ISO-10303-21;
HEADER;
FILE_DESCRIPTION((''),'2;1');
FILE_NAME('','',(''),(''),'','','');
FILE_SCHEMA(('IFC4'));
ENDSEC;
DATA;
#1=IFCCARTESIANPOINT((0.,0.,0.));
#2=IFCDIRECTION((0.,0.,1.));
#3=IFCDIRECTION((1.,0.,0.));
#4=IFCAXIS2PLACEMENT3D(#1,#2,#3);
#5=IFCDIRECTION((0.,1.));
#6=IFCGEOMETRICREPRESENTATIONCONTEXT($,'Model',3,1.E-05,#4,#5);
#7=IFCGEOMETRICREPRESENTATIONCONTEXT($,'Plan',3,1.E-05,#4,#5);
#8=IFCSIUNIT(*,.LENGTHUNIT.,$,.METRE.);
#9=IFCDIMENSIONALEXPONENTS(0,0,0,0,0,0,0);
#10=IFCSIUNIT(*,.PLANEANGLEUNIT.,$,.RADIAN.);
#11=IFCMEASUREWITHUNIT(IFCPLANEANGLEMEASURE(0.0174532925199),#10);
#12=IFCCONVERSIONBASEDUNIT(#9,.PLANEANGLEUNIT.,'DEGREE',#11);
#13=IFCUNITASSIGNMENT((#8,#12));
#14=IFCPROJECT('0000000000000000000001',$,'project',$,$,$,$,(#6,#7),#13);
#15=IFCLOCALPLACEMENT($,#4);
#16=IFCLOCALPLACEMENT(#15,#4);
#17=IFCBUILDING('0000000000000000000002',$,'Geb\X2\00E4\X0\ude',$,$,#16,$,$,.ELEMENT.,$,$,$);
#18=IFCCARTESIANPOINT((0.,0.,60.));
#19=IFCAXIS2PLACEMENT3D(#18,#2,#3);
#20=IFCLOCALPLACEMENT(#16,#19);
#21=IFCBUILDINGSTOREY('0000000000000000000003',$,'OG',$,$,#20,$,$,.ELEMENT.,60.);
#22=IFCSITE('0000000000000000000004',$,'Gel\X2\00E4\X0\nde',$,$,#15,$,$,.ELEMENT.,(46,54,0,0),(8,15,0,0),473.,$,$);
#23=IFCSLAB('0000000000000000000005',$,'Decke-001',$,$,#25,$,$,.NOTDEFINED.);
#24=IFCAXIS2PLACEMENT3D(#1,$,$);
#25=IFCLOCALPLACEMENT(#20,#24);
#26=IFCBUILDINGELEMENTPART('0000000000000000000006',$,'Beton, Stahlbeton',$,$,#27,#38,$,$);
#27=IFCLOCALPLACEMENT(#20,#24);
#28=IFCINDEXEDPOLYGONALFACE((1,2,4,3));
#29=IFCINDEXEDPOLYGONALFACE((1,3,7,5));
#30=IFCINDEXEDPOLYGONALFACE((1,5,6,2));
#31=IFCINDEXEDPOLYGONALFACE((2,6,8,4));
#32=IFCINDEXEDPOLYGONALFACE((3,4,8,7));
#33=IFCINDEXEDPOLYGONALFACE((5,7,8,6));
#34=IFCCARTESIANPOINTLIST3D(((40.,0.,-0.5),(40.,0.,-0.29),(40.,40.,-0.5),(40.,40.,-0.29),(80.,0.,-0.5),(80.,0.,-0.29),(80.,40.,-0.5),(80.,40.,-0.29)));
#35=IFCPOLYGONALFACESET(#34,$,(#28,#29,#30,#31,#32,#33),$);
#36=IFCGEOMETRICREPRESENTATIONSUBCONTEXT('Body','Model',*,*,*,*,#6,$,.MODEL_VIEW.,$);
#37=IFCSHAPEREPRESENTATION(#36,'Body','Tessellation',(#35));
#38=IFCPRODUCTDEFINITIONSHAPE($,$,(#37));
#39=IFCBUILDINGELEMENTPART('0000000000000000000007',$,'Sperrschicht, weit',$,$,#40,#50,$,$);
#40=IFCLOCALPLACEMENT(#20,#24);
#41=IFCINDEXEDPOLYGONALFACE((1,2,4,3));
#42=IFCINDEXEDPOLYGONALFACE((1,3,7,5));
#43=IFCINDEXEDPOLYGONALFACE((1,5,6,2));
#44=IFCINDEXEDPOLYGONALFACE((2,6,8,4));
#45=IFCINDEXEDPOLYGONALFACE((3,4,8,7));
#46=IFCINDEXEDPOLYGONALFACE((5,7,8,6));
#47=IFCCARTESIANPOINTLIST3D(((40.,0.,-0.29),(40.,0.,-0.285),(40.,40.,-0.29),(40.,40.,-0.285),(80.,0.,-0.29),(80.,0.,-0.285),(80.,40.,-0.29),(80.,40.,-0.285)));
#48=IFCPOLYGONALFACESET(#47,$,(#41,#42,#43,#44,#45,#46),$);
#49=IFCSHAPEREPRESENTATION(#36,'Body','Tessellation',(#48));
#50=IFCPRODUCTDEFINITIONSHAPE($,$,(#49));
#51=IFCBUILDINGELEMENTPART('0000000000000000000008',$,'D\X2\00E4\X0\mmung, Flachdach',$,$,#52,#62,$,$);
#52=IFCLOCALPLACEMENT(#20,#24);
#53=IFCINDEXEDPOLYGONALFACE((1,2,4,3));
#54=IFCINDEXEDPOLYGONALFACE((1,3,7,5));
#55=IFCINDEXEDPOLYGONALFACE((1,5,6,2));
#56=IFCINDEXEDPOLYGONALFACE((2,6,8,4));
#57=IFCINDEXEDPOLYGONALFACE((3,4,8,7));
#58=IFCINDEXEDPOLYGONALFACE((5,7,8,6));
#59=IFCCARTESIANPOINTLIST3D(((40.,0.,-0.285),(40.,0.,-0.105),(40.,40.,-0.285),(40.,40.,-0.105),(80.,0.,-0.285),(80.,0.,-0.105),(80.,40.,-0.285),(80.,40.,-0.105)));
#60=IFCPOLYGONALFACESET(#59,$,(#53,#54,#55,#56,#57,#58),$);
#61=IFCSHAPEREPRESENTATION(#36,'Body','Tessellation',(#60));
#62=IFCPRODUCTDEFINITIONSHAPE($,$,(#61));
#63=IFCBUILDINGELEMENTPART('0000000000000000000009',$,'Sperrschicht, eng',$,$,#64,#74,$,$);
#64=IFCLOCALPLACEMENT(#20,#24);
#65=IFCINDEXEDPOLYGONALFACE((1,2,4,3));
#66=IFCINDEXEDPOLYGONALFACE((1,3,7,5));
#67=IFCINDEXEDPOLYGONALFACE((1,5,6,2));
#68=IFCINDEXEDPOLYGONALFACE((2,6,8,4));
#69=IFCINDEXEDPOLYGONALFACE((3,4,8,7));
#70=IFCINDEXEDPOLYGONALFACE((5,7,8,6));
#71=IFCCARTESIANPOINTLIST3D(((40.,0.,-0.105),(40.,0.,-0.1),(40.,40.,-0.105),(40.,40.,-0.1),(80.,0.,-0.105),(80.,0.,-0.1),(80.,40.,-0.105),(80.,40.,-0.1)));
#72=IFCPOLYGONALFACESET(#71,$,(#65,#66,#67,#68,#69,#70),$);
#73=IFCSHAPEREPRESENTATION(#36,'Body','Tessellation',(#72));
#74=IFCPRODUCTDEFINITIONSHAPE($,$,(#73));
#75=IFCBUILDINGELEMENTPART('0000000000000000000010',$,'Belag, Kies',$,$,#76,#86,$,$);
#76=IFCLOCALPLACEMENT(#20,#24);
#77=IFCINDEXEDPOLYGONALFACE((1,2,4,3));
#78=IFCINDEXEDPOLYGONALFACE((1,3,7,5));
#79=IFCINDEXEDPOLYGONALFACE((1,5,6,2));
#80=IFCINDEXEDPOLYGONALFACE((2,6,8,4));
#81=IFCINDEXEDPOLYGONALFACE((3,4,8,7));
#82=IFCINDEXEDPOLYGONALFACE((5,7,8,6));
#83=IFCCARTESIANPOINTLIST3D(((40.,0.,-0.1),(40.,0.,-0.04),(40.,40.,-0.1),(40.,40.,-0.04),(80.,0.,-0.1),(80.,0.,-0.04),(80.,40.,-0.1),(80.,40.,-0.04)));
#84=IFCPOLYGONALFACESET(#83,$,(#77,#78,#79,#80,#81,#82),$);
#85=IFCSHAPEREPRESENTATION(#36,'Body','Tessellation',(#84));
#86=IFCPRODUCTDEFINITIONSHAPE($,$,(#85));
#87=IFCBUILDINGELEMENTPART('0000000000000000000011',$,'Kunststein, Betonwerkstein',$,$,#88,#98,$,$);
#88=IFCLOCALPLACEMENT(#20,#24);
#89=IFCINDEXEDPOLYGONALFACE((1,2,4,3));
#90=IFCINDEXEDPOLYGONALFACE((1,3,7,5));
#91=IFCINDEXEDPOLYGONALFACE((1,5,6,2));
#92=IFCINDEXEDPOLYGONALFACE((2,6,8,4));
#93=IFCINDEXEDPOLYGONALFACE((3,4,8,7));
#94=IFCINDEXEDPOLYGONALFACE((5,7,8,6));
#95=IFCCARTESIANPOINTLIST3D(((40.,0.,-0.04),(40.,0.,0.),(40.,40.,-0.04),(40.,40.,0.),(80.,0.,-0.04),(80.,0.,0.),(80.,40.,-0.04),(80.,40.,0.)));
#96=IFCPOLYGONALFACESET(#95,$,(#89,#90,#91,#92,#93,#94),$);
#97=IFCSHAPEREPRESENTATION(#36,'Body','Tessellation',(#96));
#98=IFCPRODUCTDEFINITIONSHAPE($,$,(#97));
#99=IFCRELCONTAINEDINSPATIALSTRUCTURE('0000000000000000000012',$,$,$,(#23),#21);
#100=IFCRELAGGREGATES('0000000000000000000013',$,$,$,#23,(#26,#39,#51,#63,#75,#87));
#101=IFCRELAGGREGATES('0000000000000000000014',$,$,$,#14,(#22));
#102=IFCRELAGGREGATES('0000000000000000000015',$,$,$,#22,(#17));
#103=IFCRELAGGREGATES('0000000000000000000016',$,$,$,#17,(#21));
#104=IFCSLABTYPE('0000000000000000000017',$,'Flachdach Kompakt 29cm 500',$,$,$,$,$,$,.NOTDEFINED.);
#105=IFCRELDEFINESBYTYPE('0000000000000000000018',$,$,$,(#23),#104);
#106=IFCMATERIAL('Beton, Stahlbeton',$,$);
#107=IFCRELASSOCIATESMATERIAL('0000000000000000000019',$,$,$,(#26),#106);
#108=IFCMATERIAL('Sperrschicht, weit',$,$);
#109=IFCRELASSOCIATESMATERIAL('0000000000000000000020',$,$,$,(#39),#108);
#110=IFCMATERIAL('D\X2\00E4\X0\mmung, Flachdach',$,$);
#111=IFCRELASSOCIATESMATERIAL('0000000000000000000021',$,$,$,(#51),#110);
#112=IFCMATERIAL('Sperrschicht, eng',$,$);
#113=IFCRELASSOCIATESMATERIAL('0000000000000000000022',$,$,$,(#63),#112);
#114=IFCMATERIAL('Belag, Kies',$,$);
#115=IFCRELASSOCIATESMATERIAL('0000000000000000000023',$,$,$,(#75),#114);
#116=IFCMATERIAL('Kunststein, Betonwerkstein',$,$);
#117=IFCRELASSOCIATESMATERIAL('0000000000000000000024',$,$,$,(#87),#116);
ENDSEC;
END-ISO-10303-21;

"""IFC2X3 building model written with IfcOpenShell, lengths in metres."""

from ifc_helpers import new_model, entity, si_unit, converted_unit, direction, frame, origin_with_axes, place, context, subcontext, project, spatial, polyline, outline, extrude, material, type_object, element, aggregate, save


model = new_model("IFC2X3")

# Units and contexts
model_context = context("Model", 3, precision=1e-05, world=origin_with_axes(), true_north=direction((0.0, 1.0)))
plan_context = context("Plan", 3, precision=1e-05, world=origin_with_axes(), true_north=direction((0.0, 1.0)))
body_context = subcontext(model_context, "Body", "Model", "MODEL_VIEW")
ifc_project = project(units=[si_unit("LENGTHUNIT", "METRE"), converted_unit("PLANEANGLEUNIT", "DEGREE", entity("IfcPlaneAngleMeasure", 0.0174532925199), si_unit("PLANEANGLEUNIT", "RADIAN"), dimensions=[0, 0, 0, 0, 0, 0, 0])], contexts=[model_context, plan_context])

# Site, building, storey
site_placement = place(None, origin_with_axes())
site = spatial("IfcSite", under=ifc_project, at=site_placement, Name="Gelände", CompositionType="ELEMENT", RefLatitude=(46, 54, 0, 0), RefLongitude=(8, 15, 0, 0), RefElevation=473.0)
building_placement = place(site_placement, origin_with_axes())
building = spatial("IfcBuilding", under=site, at=building_placement, Name="Gebäude", CompositionType="ELEMENT")
storey_placement = place(building_placement, frame((0.0, 0.0, 60.0), z_axis=(0.0, 0.0, 1.0), x_axis=(1.0, 0.0, 0.0)))
storey = spatial("IfcBuildingStorey", under=building, at=storey_placement, Name="OG", CompositionType="ELEMENT", Elevation=60.0)

# Slab, building element parts
slab_type = type_object("IfcSlabType", Name="Flachdach Kompakt 29cm 500", PredefinedType="NOTDEFINED")
slab_placement = place(storey_placement, frame((40.0, 0.0, 0.0), z_axis=(0.0, 0.0, 1.0), x_axis=(1.0, 0.0, 0.0)))
slab = element("IfcSlab", 1, at=slab_placement, inside=storey, type_object=slab_type, Name="Decke-001", PredefinedType="NOTDEFINED")
ifc_material_1 = material(Name="Beton, Stahlbeton")
building_element_part_1_placement = place(slab_placement, origin_with_axes())
building_element_part_1 = element("IfcBuildingElementPart", 2, at=building_element_part_1_placement, material=ifc_material_1, Name="Beton, Stahlbeton", context=body_context, shape_type="SweptSolid", body=[
    extrude(outline(polyline([(0.0, 0.0), (40.0, 0.0), (40.0, 40.0), (0.0, 40.0), (0.0, 0.0)])), frame((0.0, 0.0, -0.5), z_axis=(0.0, 0.0, 1.0), x_axis=(1.0, 0.0, 0.0)), (0.0, 0.0, 1.0), 0.21),
])
ifc_material_2 = material(Name="Sperrschicht, weit")
building_element_part_2_placement = place(slab_placement, origin_with_axes())
building_element_part_2 = element("IfcBuildingElementPart", 3, at=building_element_part_2_placement, material=ifc_material_2, Name="Sperrschicht, weit", context=body_context, shape_type="SweptSolid", body=[
    extrude(outline(polyline([(0.0, 0.0), (40.0, 0.0), (40.0, 40.0), (0.0, 40.0), (0.0, 0.0)])), frame((0.0, 0.0, -0.29), z_axis=(0.0, 0.0, 1.0), x_axis=(1.0, 0.0, 0.0)), (0.0, 0.0, 1.0), 0.005),
])
ifc_material_3 = material(Name="Dämmung, Flachdach")
building_element_part_3_placement = place(slab_placement, origin_with_axes())
building_element_part_3 = element("IfcBuildingElementPart", 4, at=building_element_part_3_placement, material=ifc_material_3, Name="Dämmung, Flachdach", context=body_context, shape_type="SweptSolid", body=[
    extrude(outline(polyline([(0.0, 0.0), (40.0, 0.0), (40.0, 40.0), (0.0, 40.0), (0.0, 0.0)])), frame((0.0, 0.0, -0.285), z_axis=(0.0, 0.0, 1.0), x_axis=(1.0, 0.0, 0.0)), (0.0, 0.0, 1.0), 0.18),
])
ifc_material_4 = material(Name="Sperrschicht, eng")
building_element_part_4_placement = place(slab_placement, origin_with_axes())
building_element_part_4 = element("IfcBuildingElementPart", 5, at=building_element_part_4_placement, material=ifc_material_4, Name="Sperrschicht, eng", context=body_context, shape_type="SweptSolid", body=[
    extrude(outline(polyline([(0.0, 0.0), (40.0, 0.0), (40.0, 40.0), (0.0, 40.0), (0.0, 0.0)])), frame((0.0, 0.0, -0.105), z_axis=(0.0, 0.0, 1.0), x_axis=(1.0, 0.0, 0.0)), (0.0, 0.0, 1.0), 0.005),
])
ifc_material_5 = material(Name="Belag, Kies")
building_element_part_5_placement = place(slab_placement, origin_with_axes())
building_element_part_5 = element("IfcBuildingElementPart", 6, at=building_element_part_5_placement, material=ifc_material_5, Name="Belag, Kies", context=body_context, shape_type="SweptSolid", body=[
    extrude(outline(polyline([(0.0, 0.0), (40.0, 0.0), (40.0, 40.0), (0.0, 40.0), (0.0, 0.0)])), frame((0.0, 0.0, -0.1), z_axis=(0.0, 0.0, 1.0), x_axis=(1.0, 0.0, 0.0)), (0.0, 0.0, 1.0), 0.06),
])
ifc_material_6 = material(Name="Kunststein, Betonwerkstein")
building_element_part_6_placement = place(slab_placement, origin_with_axes())
building_element_part_6 = element("IfcBuildingElementPart", 7, at=building_element_part_6_placement, material=ifc_material_6, Name="Kunststein, Betonwerkstein", context=body_context, shape_type="SweptSolid", body=[
    extrude(outline(polyline([(0.0, 0.0), (40.0, 0.0), (40.0, 40.0), (0.0, 40.0), (0.0, 0.0)])), frame((0.0, 0.0, -0.04), z_axis=(0.0, 0.0, 1.0), x_axis=(1.0, 0.0, 0.0)), (0.0, 0.0, 1.0), 0.04),
])
aggregate(slab, [building_element_part_1, building_element_part_2, building_element_part_3, building_element_part_4, building_element_part_5, building_element_part_6])

save(model, "model.ifc")
